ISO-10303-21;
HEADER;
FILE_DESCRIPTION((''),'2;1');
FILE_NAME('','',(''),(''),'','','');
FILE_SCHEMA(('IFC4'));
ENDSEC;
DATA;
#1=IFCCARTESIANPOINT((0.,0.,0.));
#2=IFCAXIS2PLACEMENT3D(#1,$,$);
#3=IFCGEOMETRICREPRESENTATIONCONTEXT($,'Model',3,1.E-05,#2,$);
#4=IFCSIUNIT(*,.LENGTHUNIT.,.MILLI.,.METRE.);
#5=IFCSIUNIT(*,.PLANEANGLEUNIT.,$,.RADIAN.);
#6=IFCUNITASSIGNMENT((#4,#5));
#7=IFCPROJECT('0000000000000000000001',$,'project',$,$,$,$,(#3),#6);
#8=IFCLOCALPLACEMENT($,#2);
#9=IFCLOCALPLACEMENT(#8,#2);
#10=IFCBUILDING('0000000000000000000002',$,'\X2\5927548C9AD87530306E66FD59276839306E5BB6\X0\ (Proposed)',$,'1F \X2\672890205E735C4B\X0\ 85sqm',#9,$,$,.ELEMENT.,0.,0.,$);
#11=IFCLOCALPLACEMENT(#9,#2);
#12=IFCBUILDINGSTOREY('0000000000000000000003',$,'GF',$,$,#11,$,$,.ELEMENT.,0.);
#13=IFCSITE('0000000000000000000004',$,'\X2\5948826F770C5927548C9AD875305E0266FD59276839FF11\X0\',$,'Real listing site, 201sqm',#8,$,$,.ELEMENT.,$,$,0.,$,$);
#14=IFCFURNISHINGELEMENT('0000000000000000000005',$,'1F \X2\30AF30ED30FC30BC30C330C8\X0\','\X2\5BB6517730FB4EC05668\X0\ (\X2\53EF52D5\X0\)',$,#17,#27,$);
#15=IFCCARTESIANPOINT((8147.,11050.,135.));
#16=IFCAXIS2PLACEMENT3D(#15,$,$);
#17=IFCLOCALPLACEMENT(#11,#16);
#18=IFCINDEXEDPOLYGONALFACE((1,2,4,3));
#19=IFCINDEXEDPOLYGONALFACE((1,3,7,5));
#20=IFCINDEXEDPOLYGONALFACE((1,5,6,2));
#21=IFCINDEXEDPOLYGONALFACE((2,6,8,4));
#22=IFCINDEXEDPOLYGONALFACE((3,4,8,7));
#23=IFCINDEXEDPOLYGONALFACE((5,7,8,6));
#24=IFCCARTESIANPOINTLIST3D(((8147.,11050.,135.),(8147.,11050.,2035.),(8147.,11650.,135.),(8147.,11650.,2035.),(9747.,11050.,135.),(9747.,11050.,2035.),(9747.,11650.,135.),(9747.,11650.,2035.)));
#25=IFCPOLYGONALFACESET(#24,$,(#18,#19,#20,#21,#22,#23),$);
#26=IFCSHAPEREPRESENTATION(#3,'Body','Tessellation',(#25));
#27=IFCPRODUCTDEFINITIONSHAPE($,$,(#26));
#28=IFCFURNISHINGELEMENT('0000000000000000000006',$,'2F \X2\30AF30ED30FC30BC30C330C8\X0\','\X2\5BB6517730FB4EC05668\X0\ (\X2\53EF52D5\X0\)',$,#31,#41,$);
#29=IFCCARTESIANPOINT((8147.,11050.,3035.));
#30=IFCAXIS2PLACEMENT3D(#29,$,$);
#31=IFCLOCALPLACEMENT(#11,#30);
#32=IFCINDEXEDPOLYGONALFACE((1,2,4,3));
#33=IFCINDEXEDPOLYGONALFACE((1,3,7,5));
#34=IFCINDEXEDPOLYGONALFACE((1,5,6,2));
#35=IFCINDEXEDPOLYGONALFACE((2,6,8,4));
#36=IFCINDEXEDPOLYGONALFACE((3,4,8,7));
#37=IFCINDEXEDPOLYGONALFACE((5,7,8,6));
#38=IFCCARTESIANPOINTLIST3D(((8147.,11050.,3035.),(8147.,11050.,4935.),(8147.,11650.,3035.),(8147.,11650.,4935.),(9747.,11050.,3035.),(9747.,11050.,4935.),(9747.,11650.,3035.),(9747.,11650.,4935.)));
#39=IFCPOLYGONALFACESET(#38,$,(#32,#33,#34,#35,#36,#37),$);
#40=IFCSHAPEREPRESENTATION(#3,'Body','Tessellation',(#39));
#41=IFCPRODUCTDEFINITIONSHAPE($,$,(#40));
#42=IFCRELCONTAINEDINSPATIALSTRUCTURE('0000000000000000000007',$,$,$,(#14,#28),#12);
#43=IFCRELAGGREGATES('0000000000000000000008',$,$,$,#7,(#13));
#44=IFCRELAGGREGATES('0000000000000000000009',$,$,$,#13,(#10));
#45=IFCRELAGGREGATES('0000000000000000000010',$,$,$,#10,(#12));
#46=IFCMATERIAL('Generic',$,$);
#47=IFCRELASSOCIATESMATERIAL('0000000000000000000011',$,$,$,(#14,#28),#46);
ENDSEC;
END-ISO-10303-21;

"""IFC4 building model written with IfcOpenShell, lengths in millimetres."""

from ifc_helpers import new_model, si_unit, frame, frame_2d, origin, place, context, project, spatial, rectangle, extrude, material, element, save


model = new_model("IFC4")

# Units and contexts
model_context = context("Model", 3, precision=1e-05, world=origin())
ifc_project = project(units=[si_unit("LENGTHUNIT", "METRE", prefix="MILLI"), si_unit("PLANEANGLEUNIT", "RADIAN")], contexts=[model_context])

# Site, building, storey
site_placement = place(None, origin())
site = spatial("IfcSite", under=ifc_project, at=site_placement, Name="奈良県大和高田市曽大根１", ObjectType="Real listing site, 201sqm", CompositionType="ELEMENT", RefElevation=0.0)
building_placement = place(site_placement, origin())
building = spatial("IfcBuilding", under=site, at=building_placement, Name="大和高田の曽大根の家 (Proposed)", ObjectType="1F 木造平屋 85sqm", CompositionType="ELEMENT", ElevationOfRefHeight=0.0, ElevationOfTerrain=0.0)
storey_placement = place(building_placement, origin())
storey = spatial("IfcBuildingStorey", under=building, at=storey_placement, Name="GF", CompositionType="ELEMENT", Elevation=0.0)

# Shared definitions
ifc_material_1 = material(Name="Generic")

# Furnishing elements
furnishing_1_placement = place(storey_placement, frame((8147.0, 11050.0, 135.0)))
element("IfcFurnishingElement", 1, at=furnishing_1_placement, inside=storey, material=ifc_material_1, Name="1F クローゼット", Description="家具・什器 (可動)", context=model_context, shape_type="SweptSolid", body=[
    extrude(rectangle(XDim=1600.0, YDim=600.0, at=frame_2d((800.0, 300.0))), frame((8147.0, 11050.0, 135.0)), (0.0, 0.0, 1.0), 1900.0),
])
furnishing_2_placement = place(storey_placement, frame((8147.0, 11050.0, 3035.0)))
element("IfcFurnishingElement", 2, at=furnishing_2_placement, inside=storey, material=ifc_material_1, Name="2F クローゼット", Description="家具・什器 (可動)", context=model_context, shape_type="SweptSolid", body=[
    extrude(rectangle(XDim=1600.0, YDim=600.0, at=frame_2d((800.0, 300.0))), frame((8147.0, 11050.0, 3035.0)), (0.0, 0.0, 1.0), 1900.0),
])

save(model, "model.ifc")
